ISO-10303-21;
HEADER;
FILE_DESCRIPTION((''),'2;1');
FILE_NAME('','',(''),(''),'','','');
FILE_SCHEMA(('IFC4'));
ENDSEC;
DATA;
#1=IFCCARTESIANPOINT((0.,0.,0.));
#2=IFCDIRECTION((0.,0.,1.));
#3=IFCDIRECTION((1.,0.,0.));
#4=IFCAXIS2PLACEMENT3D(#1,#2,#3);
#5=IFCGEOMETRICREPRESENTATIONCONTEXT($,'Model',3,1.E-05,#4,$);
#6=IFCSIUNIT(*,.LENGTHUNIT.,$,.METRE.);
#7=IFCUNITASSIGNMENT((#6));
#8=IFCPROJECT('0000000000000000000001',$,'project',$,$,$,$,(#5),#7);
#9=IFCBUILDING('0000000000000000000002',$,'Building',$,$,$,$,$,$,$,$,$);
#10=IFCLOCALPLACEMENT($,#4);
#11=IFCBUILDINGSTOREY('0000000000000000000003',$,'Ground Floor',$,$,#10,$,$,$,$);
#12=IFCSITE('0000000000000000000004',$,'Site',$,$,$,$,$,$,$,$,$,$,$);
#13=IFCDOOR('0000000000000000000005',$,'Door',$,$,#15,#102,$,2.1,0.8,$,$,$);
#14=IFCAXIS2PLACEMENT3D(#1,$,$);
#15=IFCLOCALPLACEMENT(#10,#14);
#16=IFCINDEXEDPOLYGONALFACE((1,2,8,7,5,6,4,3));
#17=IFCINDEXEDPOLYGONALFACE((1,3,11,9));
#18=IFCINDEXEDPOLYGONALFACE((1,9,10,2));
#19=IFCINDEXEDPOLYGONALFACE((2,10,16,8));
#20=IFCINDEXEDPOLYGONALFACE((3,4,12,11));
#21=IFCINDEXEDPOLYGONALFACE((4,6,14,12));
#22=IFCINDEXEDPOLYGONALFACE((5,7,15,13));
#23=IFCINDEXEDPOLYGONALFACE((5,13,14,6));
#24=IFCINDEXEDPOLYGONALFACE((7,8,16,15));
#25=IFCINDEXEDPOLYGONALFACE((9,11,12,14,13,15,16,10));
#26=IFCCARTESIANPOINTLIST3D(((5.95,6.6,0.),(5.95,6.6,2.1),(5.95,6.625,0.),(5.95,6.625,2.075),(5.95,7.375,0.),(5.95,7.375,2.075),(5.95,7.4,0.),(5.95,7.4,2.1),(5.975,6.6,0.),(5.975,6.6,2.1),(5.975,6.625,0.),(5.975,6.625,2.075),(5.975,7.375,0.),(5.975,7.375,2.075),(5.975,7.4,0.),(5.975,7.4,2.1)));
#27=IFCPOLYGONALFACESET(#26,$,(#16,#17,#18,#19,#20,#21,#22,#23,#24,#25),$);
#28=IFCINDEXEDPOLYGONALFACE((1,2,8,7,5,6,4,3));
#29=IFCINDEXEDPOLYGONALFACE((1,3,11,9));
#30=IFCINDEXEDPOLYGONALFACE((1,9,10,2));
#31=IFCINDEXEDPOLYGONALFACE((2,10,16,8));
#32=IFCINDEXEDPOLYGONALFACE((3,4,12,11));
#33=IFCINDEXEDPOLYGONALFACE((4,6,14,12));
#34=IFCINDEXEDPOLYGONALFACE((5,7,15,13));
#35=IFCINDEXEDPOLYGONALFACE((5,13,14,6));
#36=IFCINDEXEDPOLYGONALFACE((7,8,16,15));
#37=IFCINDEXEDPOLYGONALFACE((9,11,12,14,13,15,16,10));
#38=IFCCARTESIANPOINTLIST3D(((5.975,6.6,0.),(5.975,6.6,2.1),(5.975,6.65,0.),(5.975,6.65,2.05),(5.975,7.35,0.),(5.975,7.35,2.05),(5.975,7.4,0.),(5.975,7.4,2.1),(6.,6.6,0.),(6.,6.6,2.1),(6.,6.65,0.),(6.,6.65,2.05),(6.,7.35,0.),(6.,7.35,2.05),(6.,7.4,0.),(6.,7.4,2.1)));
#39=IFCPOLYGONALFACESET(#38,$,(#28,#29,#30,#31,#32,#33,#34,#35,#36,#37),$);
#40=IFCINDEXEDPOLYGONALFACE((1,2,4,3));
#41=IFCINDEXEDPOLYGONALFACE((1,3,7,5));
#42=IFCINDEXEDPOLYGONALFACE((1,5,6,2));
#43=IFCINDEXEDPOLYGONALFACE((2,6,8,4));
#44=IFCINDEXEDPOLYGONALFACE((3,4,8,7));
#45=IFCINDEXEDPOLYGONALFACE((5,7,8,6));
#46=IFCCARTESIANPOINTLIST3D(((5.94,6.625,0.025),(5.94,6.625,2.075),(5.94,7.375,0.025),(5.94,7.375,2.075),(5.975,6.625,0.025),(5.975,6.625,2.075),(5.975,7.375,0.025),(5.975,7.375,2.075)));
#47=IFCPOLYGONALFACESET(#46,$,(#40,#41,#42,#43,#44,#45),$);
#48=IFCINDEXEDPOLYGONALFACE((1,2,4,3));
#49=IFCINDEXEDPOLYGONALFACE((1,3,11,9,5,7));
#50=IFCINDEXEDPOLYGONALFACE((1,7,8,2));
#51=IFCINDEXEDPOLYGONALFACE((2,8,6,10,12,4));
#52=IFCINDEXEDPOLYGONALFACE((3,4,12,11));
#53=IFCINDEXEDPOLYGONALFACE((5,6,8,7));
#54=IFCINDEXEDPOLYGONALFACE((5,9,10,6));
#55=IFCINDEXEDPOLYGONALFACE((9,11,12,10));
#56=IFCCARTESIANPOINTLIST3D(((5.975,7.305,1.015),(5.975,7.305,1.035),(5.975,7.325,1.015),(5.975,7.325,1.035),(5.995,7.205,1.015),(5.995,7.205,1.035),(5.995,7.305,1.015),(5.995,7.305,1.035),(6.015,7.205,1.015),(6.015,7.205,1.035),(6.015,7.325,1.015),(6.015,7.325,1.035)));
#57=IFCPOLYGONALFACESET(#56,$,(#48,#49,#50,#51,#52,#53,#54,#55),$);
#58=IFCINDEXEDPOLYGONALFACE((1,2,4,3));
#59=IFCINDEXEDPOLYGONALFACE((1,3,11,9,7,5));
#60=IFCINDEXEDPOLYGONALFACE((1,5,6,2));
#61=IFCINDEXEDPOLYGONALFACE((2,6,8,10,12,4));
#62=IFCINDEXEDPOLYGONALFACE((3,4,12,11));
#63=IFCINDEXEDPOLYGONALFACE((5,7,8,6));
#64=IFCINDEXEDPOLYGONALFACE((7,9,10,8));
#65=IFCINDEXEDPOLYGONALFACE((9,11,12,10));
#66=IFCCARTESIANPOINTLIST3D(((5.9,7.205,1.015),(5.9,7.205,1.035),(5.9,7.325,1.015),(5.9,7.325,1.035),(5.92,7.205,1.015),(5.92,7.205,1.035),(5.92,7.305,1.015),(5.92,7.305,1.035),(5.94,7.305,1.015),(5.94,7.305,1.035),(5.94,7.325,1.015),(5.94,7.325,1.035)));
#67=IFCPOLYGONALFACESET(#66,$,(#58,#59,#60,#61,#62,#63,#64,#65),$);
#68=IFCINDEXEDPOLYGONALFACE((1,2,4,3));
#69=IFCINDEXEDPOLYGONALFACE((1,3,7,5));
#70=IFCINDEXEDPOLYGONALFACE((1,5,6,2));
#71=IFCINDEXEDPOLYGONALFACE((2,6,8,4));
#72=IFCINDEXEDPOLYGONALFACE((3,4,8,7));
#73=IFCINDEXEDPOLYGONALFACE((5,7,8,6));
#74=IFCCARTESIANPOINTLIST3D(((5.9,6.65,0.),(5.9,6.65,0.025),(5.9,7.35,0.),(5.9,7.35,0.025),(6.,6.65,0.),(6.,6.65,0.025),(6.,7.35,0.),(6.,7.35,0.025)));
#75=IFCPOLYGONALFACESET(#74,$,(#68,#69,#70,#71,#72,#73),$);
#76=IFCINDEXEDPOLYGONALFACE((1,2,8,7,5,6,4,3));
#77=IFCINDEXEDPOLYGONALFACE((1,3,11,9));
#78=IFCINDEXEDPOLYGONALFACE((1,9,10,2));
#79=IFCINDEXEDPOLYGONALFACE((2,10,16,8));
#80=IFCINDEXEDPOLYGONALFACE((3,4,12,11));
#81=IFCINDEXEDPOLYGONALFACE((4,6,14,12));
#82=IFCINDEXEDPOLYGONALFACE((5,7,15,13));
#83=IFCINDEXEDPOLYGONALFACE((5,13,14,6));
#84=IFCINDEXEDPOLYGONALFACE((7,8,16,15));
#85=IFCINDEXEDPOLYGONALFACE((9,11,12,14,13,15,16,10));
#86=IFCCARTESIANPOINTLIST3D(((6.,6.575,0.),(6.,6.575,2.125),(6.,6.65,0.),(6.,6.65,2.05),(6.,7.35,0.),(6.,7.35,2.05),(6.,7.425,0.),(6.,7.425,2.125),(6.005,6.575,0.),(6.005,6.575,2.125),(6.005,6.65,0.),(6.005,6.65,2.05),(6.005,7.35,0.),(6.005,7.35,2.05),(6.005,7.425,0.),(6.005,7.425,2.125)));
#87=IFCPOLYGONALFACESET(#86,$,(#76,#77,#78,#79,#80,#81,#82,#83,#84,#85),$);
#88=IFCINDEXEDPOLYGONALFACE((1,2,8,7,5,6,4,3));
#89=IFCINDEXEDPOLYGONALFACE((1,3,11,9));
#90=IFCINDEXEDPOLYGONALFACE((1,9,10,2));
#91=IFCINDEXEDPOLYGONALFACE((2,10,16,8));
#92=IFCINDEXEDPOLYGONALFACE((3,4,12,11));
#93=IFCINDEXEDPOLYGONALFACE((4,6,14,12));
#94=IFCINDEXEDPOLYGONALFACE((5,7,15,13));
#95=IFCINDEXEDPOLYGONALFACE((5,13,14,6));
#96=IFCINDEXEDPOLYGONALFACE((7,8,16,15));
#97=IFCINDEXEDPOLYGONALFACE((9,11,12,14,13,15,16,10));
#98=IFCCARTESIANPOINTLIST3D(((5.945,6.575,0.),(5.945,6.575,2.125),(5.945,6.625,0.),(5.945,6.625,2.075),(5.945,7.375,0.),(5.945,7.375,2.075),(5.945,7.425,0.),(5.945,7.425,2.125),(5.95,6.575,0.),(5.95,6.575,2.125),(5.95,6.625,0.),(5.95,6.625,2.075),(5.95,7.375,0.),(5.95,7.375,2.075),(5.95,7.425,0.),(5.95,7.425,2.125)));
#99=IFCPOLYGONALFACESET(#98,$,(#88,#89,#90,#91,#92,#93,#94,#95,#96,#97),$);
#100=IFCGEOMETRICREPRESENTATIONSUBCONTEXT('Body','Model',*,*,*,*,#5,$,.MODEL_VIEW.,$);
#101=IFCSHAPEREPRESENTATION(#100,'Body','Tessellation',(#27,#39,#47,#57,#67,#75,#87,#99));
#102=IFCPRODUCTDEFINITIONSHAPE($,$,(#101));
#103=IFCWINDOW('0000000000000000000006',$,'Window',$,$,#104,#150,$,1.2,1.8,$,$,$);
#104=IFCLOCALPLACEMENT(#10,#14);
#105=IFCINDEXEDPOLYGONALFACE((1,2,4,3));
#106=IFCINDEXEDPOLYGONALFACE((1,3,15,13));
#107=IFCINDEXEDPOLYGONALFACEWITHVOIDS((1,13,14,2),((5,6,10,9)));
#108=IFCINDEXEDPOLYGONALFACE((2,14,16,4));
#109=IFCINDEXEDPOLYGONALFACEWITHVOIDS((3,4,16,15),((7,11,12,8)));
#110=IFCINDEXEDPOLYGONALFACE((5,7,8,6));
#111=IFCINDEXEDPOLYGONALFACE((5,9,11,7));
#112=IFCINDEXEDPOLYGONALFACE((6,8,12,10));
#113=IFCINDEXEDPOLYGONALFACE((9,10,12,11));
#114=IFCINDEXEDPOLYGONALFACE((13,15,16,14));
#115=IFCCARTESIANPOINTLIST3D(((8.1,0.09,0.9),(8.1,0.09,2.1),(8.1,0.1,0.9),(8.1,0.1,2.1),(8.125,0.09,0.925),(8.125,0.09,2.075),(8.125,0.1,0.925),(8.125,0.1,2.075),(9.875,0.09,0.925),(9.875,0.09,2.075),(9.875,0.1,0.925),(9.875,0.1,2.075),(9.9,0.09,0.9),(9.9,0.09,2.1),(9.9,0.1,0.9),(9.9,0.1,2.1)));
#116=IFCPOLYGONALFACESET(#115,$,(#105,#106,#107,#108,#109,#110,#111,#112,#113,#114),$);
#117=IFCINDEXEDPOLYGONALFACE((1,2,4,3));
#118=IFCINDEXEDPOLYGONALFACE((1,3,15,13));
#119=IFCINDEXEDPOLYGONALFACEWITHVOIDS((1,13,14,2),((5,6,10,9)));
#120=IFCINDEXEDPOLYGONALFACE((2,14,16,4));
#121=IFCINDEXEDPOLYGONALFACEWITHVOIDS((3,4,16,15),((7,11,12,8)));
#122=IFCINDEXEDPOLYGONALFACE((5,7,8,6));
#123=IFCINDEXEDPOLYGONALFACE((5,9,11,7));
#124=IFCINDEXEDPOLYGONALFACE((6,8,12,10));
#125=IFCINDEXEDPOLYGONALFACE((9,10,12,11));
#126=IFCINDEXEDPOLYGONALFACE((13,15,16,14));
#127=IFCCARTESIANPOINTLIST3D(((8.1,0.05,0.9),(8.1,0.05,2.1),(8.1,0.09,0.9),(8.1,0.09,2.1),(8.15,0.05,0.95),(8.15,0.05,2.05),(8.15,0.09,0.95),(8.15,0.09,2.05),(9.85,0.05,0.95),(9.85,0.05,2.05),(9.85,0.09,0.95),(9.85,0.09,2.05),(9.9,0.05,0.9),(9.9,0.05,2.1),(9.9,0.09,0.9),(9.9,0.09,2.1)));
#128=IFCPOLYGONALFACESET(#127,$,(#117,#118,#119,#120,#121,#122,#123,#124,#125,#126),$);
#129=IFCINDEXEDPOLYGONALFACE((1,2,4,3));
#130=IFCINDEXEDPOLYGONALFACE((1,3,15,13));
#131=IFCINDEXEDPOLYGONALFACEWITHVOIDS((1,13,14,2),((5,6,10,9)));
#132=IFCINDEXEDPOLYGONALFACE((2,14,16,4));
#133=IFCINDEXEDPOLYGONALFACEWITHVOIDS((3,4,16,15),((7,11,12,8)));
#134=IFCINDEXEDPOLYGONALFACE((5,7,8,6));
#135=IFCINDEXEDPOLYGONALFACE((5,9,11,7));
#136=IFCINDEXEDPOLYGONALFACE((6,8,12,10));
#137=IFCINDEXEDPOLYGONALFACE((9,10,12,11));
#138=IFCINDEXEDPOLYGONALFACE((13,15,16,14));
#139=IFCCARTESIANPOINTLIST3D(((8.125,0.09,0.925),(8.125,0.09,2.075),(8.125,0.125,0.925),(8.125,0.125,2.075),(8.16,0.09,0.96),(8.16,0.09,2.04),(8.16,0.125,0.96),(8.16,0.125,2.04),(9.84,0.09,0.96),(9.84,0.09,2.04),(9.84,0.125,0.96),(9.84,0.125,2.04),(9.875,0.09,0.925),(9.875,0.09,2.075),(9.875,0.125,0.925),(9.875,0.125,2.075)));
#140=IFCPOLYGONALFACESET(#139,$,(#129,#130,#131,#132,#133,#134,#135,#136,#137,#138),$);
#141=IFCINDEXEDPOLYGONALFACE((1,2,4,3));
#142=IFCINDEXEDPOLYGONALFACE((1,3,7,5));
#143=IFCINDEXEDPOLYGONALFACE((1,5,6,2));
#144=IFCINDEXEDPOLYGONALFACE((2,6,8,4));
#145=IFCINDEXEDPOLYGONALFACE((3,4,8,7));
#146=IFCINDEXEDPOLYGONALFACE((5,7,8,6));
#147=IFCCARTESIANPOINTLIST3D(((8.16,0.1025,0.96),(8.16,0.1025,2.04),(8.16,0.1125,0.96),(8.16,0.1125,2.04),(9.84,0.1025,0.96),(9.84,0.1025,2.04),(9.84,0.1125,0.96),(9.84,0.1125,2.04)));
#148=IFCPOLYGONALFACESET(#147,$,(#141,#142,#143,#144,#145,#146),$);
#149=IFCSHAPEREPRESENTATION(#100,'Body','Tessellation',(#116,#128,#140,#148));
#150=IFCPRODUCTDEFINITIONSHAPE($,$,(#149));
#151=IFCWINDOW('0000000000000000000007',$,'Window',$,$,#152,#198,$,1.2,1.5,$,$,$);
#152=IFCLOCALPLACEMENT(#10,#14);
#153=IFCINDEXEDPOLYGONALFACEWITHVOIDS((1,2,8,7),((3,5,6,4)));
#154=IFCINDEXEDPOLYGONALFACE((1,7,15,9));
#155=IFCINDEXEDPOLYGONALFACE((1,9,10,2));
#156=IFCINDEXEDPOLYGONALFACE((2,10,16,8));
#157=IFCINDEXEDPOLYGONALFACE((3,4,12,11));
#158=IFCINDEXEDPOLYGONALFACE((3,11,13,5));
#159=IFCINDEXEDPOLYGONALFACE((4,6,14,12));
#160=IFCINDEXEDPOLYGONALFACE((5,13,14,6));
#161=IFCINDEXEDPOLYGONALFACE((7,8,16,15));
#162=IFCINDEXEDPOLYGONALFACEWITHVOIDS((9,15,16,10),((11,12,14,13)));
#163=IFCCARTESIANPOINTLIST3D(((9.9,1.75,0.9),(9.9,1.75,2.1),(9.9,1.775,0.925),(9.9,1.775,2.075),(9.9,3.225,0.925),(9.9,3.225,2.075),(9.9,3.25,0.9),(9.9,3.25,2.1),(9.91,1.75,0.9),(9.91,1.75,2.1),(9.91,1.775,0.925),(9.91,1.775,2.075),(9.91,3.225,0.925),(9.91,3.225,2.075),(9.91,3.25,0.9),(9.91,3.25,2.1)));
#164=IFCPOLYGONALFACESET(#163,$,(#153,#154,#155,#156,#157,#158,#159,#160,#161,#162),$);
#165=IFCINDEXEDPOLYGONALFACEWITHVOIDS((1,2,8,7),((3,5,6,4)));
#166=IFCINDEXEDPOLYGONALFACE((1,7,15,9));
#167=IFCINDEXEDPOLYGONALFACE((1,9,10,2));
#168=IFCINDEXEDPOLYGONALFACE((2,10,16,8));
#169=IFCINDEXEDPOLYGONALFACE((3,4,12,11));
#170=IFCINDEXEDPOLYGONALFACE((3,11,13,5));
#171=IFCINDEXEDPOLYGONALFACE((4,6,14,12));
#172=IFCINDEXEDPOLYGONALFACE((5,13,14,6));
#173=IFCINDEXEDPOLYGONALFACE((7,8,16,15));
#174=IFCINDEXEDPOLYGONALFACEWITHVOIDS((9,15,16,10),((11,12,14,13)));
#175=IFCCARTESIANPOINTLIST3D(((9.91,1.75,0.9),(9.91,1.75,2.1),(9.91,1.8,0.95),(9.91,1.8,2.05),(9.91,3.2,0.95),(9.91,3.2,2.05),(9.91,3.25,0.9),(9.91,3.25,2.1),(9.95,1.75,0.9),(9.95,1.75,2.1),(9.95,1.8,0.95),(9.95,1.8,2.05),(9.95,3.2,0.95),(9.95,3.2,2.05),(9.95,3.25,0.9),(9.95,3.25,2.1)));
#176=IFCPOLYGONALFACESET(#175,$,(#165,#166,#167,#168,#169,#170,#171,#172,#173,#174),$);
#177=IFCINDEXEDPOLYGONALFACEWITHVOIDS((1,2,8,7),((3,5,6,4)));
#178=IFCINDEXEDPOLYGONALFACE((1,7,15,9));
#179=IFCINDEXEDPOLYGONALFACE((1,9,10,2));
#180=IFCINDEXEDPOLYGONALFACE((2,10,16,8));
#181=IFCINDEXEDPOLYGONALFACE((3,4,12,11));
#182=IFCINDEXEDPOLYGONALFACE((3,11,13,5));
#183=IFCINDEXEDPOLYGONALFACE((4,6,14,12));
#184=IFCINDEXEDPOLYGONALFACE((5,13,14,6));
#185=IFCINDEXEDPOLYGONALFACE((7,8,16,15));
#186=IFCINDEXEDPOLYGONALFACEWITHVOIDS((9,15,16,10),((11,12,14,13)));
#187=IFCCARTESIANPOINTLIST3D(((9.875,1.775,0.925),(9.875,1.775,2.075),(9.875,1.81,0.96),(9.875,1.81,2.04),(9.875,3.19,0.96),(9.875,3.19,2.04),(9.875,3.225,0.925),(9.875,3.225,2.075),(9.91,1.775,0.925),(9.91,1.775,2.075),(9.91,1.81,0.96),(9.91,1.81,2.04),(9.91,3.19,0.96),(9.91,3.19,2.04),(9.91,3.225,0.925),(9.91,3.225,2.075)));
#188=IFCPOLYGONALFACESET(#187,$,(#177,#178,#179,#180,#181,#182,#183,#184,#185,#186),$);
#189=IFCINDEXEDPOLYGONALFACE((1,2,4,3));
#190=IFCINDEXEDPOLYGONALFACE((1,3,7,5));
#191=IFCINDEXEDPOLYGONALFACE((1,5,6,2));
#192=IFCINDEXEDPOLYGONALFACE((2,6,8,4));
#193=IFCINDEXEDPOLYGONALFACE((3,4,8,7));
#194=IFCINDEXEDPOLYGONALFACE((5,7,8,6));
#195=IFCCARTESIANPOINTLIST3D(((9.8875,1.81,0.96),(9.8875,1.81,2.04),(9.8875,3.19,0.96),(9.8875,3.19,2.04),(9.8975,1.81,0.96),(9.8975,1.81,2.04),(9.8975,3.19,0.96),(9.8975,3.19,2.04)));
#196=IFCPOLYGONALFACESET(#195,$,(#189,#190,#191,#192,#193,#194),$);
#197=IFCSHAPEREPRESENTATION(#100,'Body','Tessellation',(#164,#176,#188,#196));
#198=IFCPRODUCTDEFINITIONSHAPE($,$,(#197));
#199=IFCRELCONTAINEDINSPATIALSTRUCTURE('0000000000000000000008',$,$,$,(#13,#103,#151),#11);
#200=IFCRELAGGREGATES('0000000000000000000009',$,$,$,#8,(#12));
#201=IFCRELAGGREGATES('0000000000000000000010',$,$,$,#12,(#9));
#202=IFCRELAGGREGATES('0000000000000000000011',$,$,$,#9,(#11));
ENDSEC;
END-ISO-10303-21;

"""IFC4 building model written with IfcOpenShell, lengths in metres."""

from ifc_helpers import new_model, si_unit, frame, origin_with_axes, place, context, subcontext, project, spatial, line, indexed_curve, outline, extrude, element, save


model = new_model("IFC4")

# Units and contexts
model_context = context("Model", 3, precision=1e-05, world=origin_with_axes())
body_context = subcontext(model_context, "Body", "Model", "MODEL_VIEW")
ifc_project = project(units=[si_unit("LENGTHUNIT", "METRE")], contexts=[model_context])

# Site, building, storey
site = spatial("IfcSite", under=ifc_project, Name="Site")
building = spatial("IfcBuilding", under=site, Name="Building")
storey_placement = place(None, origin_with_axes())
storey = spatial("IfcBuildingStorey", under=building, at=storey_placement, Name="Ground Floor")

# Door
door_1_placement = place(storey_placement, frame((6.0, 6.6, 0.0), z_axis=(0.0, 0.0, 1.0), x_axis=(0.0, 1.0, 0.0)))
element("IfcDoor", 1, at=door_1_placement, inside=storey, Name="Door", OverallHeight=2.1, OverallWidth=0.8, context=body_context, shape_type="SweptSolid", body=[
    extrude(outline(indexed_curve([(0.0, 0.0), (0.0, 2.1), (0.8, 2.1), (0.8, 0.0), (0.775, 0.0), (0.775, 2.075), (0.025, 2.075), (0.025, 0.0)], segments=[line(1, 2, 3, 4, 5, 6, 7, 8, 1)])), frame((0.0, 0.025, 0.0), z_axis=(0.0, -1.0, 0.0), x_axis=(1.0, 0.0, 0.0)), (0.0, 0.0, -1.0), 0.025),
    extrude(outline(indexed_curve([(0.0, 0.0), (0.0, 2.1), (0.8, 2.1), (0.8, 0.0), (0.75, 0.0), (0.75, 2.05), (0.05, 2.05), (0.05, 0.0)], segments=[line(1, 2, 3, 4, 5, 6, 7, 8, 1)])), frame((0.0, 0.0, 0.0), z_axis=(0.0, -1.0, 0.0), x_axis=(1.0, 0.0, 0.0)), (0.0, 0.0, -1.0), 0.025),
    extrude(outline(indexed_curve([(0.0, 0.0), (0.75, 0.0), (0.75, 0.035), (0.0, 0.035)], segments=[line(1, 2, 3, 4, 1)])), frame((0.025, 0.025, 0.025), z_axis=(0.0, 0.0, 1.0), x_axis=(1.0, 0.0, 0.0)), (0.0, 0.0, 1.0), 2.05),
    extrude(outline(indexed_curve([(0.0, 0.0), (0.0, -0.04), (-0.12, -0.04), (-0.12, -0.02), (-0.02, -0.02), (-0.02, 0.0)], segments=[line(1, 2, 3, 4, 5, 6, 1)])), frame((0.725, 0.025, 1.015), z_axis=(0.0, 0.0, 1.0), x_axis=(1.0, 0.0, 0.0)), (0.0, 0.0, 1.0), 0.02),
    extrude(outline(indexed_curve([(0.0, 0.0), (0.0, 0.04), (-0.12, 0.04), (-0.12, 0.02), (-0.02, 0.02), (-0.02, 0.0)], segments=[line(1, 2, 3, 4, 5, 6, 1)])), frame((0.725, 0.06, 1.015), z_axis=(0.0, 0.0, 1.0), x_axis=(1.0, 0.0, 0.0)), (0.0, 0.0, 1.0), 0.02),
    extrude(outline(indexed_curve([(0.0, 0.0), (0.7, 0.0), (0.7, 0.1), (0.0, 0.1)], segments=[line(1, 2, 3, 4, 1)])), frame((0.05, 0.0, 0.0), z_axis=(0.0, 0.0, 1.0), x_axis=(1.0, 0.0, 0.0)), (0.0, 0.0, 1.0), 0.025),
    extrude(outline(indexed_curve([(0.0, 0.0), (0.0, 2.125), (0.85, 2.125), (0.85, 0.0), (0.775, 0.0), (0.775, 2.05), (0.075, 2.05), (0.075, 0.0)], segments=[line(1, 2, 3, 4, 5, 6, 7, 8, 1)])), frame((-0.025, -0.005, 0.0), z_axis=(0.0, -1.0, 0.0), x_axis=(1.0, 0.0, 0.0)), (0.0, 0.0, -1.0), 0.005),
    extrude(outline(indexed_curve([(0.0, 0.0), (0.0, 2.125), (0.85, 2.125), (0.85, 0.0), (0.8, 0.0), (0.8, 2.075), (0.05, 2.075), (0.05, 0.0)], segments=[line(1, 2, 3, 4, 5, 6, 7, 8, 1)])), frame((-0.025, 0.05, 0.0), z_axis=(0.0, -1.0, 0.0), x_axis=(1.0, 0.0, 0.0)), (0.0, 0.0, -1.0), 0.005),
])

# Windows
window_1_placement = place(storey_placement, frame((8.1, 0.0, 0.9), z_axis=(0.0, 0.0, 1.0), x_axis=(1.0, 0.0, 0.0)))
element("IfcWindow", 2, at=window_1_placement, inside=storey, Name="Window", OverallHeight=1.2, OverallWidth=1.8, context=body_context, shape_type="SweptSolid", body=[
    extrude(outline(indexed_curve([(0.0, 0.0), (1.8, 0.0), (1.8, 1.2), (0.0, 1.2)], segments=[line(1, 2, 3, 4, 1)]), holes=[indexed_curve([(0.025, 0.025), (1.775, 0.025), (1.775, 1.175), (0.025, 1.175)], segments=[line(1, 2, 3, 4, 1)])]), frame((0.0, 0.09, 0.0), z_axis=(0.0, -1.0, 0.0), x_axis=(1.0, 0.0, 0.0)), (0.0, 0.0, -1.0), 0.01),
    extrude(outline(indexed_curve([(0.0, 0.0), (1.8, 0.0), (1.8, 1.2), (0.0, 1.2)], segments=[line(1, 2, 3, 4, 1)]), holes=[indexed_curve([(0.05, 0.05), (1.75, 0.05), (1.75, 1.15), (0.05, 1.15)], segments=[line(1, 2, 3, 4, 1)])]), frame((0.0, 0.05, 0.0), z_axis=(0.0, -1.0, 0.0), x_axis=(1.0, 0.0, 0.0)), (0.0, 0.0, -1.0), 0.04),
    extrude(outline(indexed_curve([(0.0, 0.0), (1.75, 0.0), (1.75, 1.15), (0.0, 1.15)], segments=[line(1, 2, 3, 4, 1)]), holes=[indexed_curve([(0.035, 0.035), (1.715, 0.035), (1.715, 1.115), (0.035, 1.115)], segments=[line(1, 2, 3, 4, 1)])]), frame((0.025, 0.09, 0.025), z_axis=(0.0, -1.0, 0.0), x_axis=(1.0, 0.0, 0.0)), (0.0, 0.0, -1.0), 0.035),
    extrude(outline(indexed_curve([(0.035, 0.035), (1.715, 0.035), (1.715, 1.115), (0.035, 1.115)], segments=[line(1, 2, 3, 4, 1)])), frame((0.025, 0.1025, 0.025), z_axis=(0.0, -1.0, 0.0), x_axis=(1.0, 0.0, 0.0)), (0.0, 0.0, -1.0), 0.01),
])
window_2_placement = place(storey_placement, frame((10.0, 1.75, 0.9), z_axis=(0.0, 0.0, 1.0), x_axis=(0.0, 1.0, 0.0)))
element("IfcWindow", 3, at=window_2_placement, inside=storey, Name="Window", OverallHeight=1.2, OverallWidth=1.5, context=body_context, shape_type="SweptSolid", body=[
    extrude(outline(indexed_curve([(0.0, 0.0), (1.5, 0.0), (1.5, 1.2), (0.0, 1.2)], segments=[line(1, 2, 3, 4, 1)]), holes=[indexed_curve([(0.025, 0.025), (1.475, 0.025), (1.475, 1.175), (0.025, 1.175)], segments=[line(1, 2, 3, 4, 1)])]), frame((0.0, 0.09, 0.0), z_axis=(0.0, -1.0, 0.0), x_axis=(1.0, 0.0, 0.0)), (0.0, 0.0, -1.0), 0.01),
    extrude(outline(indexed_curve([(0.0, 0.0), (1.5, 0.0), (1.5, 1.2), (0.0, 1.2)], segments=[line(1, 2, 3, 4, 1)]), holes=[indexed_curve([(0.05, 0.05), (1.45, 0.05), (1.45, 1.15), (0.05, 1.15)], segments=[line(1, 2, 3, 4, 1)])]), frame((0.0, 0.05, 0.0), z_axis=(0.0, -1.0, 0.0), x_axis=(1.0, 0.0, 0.0)), (0.0, 0.0, -1.0), 0.04),
    extrude(outline(indexed_curve([(0.0, 0.0), (1.45, 0.0), (1.45, 1.15), (0.0, 1.15)], segments=[line(1, 2, 3, 4, 1)]), holes=[indexed_curve([(0.035, 0.035), (1.415, 0.035), (1.415, 1.115), (0.035, 1.115)], segments=[line(1, 2, 3, 4, 1)])]), frame((0.025, 0.09, 0.025), z_axis=(0.0, -1.0, 0.0), x_axis=(1.0, 0.0, 0.0)), (0.0, 0.0, -1.0), 0.035),
    extrude(outline(indexed_curve([(0.035, 0.035), (1.415, 0.035), (1.415, 1.115), (0.035, 1.115)], segments=[line(1, 2, 3, 4, 1)])), frame((0.025, 0.1025, 0.025), z_axis=(0.0, -1.0, 0.0), x_axis=(1.0, 0.0, 0.0)), (0.0, 0.0, -1.0), 0.01),
])

save(model, "model.ifc")
